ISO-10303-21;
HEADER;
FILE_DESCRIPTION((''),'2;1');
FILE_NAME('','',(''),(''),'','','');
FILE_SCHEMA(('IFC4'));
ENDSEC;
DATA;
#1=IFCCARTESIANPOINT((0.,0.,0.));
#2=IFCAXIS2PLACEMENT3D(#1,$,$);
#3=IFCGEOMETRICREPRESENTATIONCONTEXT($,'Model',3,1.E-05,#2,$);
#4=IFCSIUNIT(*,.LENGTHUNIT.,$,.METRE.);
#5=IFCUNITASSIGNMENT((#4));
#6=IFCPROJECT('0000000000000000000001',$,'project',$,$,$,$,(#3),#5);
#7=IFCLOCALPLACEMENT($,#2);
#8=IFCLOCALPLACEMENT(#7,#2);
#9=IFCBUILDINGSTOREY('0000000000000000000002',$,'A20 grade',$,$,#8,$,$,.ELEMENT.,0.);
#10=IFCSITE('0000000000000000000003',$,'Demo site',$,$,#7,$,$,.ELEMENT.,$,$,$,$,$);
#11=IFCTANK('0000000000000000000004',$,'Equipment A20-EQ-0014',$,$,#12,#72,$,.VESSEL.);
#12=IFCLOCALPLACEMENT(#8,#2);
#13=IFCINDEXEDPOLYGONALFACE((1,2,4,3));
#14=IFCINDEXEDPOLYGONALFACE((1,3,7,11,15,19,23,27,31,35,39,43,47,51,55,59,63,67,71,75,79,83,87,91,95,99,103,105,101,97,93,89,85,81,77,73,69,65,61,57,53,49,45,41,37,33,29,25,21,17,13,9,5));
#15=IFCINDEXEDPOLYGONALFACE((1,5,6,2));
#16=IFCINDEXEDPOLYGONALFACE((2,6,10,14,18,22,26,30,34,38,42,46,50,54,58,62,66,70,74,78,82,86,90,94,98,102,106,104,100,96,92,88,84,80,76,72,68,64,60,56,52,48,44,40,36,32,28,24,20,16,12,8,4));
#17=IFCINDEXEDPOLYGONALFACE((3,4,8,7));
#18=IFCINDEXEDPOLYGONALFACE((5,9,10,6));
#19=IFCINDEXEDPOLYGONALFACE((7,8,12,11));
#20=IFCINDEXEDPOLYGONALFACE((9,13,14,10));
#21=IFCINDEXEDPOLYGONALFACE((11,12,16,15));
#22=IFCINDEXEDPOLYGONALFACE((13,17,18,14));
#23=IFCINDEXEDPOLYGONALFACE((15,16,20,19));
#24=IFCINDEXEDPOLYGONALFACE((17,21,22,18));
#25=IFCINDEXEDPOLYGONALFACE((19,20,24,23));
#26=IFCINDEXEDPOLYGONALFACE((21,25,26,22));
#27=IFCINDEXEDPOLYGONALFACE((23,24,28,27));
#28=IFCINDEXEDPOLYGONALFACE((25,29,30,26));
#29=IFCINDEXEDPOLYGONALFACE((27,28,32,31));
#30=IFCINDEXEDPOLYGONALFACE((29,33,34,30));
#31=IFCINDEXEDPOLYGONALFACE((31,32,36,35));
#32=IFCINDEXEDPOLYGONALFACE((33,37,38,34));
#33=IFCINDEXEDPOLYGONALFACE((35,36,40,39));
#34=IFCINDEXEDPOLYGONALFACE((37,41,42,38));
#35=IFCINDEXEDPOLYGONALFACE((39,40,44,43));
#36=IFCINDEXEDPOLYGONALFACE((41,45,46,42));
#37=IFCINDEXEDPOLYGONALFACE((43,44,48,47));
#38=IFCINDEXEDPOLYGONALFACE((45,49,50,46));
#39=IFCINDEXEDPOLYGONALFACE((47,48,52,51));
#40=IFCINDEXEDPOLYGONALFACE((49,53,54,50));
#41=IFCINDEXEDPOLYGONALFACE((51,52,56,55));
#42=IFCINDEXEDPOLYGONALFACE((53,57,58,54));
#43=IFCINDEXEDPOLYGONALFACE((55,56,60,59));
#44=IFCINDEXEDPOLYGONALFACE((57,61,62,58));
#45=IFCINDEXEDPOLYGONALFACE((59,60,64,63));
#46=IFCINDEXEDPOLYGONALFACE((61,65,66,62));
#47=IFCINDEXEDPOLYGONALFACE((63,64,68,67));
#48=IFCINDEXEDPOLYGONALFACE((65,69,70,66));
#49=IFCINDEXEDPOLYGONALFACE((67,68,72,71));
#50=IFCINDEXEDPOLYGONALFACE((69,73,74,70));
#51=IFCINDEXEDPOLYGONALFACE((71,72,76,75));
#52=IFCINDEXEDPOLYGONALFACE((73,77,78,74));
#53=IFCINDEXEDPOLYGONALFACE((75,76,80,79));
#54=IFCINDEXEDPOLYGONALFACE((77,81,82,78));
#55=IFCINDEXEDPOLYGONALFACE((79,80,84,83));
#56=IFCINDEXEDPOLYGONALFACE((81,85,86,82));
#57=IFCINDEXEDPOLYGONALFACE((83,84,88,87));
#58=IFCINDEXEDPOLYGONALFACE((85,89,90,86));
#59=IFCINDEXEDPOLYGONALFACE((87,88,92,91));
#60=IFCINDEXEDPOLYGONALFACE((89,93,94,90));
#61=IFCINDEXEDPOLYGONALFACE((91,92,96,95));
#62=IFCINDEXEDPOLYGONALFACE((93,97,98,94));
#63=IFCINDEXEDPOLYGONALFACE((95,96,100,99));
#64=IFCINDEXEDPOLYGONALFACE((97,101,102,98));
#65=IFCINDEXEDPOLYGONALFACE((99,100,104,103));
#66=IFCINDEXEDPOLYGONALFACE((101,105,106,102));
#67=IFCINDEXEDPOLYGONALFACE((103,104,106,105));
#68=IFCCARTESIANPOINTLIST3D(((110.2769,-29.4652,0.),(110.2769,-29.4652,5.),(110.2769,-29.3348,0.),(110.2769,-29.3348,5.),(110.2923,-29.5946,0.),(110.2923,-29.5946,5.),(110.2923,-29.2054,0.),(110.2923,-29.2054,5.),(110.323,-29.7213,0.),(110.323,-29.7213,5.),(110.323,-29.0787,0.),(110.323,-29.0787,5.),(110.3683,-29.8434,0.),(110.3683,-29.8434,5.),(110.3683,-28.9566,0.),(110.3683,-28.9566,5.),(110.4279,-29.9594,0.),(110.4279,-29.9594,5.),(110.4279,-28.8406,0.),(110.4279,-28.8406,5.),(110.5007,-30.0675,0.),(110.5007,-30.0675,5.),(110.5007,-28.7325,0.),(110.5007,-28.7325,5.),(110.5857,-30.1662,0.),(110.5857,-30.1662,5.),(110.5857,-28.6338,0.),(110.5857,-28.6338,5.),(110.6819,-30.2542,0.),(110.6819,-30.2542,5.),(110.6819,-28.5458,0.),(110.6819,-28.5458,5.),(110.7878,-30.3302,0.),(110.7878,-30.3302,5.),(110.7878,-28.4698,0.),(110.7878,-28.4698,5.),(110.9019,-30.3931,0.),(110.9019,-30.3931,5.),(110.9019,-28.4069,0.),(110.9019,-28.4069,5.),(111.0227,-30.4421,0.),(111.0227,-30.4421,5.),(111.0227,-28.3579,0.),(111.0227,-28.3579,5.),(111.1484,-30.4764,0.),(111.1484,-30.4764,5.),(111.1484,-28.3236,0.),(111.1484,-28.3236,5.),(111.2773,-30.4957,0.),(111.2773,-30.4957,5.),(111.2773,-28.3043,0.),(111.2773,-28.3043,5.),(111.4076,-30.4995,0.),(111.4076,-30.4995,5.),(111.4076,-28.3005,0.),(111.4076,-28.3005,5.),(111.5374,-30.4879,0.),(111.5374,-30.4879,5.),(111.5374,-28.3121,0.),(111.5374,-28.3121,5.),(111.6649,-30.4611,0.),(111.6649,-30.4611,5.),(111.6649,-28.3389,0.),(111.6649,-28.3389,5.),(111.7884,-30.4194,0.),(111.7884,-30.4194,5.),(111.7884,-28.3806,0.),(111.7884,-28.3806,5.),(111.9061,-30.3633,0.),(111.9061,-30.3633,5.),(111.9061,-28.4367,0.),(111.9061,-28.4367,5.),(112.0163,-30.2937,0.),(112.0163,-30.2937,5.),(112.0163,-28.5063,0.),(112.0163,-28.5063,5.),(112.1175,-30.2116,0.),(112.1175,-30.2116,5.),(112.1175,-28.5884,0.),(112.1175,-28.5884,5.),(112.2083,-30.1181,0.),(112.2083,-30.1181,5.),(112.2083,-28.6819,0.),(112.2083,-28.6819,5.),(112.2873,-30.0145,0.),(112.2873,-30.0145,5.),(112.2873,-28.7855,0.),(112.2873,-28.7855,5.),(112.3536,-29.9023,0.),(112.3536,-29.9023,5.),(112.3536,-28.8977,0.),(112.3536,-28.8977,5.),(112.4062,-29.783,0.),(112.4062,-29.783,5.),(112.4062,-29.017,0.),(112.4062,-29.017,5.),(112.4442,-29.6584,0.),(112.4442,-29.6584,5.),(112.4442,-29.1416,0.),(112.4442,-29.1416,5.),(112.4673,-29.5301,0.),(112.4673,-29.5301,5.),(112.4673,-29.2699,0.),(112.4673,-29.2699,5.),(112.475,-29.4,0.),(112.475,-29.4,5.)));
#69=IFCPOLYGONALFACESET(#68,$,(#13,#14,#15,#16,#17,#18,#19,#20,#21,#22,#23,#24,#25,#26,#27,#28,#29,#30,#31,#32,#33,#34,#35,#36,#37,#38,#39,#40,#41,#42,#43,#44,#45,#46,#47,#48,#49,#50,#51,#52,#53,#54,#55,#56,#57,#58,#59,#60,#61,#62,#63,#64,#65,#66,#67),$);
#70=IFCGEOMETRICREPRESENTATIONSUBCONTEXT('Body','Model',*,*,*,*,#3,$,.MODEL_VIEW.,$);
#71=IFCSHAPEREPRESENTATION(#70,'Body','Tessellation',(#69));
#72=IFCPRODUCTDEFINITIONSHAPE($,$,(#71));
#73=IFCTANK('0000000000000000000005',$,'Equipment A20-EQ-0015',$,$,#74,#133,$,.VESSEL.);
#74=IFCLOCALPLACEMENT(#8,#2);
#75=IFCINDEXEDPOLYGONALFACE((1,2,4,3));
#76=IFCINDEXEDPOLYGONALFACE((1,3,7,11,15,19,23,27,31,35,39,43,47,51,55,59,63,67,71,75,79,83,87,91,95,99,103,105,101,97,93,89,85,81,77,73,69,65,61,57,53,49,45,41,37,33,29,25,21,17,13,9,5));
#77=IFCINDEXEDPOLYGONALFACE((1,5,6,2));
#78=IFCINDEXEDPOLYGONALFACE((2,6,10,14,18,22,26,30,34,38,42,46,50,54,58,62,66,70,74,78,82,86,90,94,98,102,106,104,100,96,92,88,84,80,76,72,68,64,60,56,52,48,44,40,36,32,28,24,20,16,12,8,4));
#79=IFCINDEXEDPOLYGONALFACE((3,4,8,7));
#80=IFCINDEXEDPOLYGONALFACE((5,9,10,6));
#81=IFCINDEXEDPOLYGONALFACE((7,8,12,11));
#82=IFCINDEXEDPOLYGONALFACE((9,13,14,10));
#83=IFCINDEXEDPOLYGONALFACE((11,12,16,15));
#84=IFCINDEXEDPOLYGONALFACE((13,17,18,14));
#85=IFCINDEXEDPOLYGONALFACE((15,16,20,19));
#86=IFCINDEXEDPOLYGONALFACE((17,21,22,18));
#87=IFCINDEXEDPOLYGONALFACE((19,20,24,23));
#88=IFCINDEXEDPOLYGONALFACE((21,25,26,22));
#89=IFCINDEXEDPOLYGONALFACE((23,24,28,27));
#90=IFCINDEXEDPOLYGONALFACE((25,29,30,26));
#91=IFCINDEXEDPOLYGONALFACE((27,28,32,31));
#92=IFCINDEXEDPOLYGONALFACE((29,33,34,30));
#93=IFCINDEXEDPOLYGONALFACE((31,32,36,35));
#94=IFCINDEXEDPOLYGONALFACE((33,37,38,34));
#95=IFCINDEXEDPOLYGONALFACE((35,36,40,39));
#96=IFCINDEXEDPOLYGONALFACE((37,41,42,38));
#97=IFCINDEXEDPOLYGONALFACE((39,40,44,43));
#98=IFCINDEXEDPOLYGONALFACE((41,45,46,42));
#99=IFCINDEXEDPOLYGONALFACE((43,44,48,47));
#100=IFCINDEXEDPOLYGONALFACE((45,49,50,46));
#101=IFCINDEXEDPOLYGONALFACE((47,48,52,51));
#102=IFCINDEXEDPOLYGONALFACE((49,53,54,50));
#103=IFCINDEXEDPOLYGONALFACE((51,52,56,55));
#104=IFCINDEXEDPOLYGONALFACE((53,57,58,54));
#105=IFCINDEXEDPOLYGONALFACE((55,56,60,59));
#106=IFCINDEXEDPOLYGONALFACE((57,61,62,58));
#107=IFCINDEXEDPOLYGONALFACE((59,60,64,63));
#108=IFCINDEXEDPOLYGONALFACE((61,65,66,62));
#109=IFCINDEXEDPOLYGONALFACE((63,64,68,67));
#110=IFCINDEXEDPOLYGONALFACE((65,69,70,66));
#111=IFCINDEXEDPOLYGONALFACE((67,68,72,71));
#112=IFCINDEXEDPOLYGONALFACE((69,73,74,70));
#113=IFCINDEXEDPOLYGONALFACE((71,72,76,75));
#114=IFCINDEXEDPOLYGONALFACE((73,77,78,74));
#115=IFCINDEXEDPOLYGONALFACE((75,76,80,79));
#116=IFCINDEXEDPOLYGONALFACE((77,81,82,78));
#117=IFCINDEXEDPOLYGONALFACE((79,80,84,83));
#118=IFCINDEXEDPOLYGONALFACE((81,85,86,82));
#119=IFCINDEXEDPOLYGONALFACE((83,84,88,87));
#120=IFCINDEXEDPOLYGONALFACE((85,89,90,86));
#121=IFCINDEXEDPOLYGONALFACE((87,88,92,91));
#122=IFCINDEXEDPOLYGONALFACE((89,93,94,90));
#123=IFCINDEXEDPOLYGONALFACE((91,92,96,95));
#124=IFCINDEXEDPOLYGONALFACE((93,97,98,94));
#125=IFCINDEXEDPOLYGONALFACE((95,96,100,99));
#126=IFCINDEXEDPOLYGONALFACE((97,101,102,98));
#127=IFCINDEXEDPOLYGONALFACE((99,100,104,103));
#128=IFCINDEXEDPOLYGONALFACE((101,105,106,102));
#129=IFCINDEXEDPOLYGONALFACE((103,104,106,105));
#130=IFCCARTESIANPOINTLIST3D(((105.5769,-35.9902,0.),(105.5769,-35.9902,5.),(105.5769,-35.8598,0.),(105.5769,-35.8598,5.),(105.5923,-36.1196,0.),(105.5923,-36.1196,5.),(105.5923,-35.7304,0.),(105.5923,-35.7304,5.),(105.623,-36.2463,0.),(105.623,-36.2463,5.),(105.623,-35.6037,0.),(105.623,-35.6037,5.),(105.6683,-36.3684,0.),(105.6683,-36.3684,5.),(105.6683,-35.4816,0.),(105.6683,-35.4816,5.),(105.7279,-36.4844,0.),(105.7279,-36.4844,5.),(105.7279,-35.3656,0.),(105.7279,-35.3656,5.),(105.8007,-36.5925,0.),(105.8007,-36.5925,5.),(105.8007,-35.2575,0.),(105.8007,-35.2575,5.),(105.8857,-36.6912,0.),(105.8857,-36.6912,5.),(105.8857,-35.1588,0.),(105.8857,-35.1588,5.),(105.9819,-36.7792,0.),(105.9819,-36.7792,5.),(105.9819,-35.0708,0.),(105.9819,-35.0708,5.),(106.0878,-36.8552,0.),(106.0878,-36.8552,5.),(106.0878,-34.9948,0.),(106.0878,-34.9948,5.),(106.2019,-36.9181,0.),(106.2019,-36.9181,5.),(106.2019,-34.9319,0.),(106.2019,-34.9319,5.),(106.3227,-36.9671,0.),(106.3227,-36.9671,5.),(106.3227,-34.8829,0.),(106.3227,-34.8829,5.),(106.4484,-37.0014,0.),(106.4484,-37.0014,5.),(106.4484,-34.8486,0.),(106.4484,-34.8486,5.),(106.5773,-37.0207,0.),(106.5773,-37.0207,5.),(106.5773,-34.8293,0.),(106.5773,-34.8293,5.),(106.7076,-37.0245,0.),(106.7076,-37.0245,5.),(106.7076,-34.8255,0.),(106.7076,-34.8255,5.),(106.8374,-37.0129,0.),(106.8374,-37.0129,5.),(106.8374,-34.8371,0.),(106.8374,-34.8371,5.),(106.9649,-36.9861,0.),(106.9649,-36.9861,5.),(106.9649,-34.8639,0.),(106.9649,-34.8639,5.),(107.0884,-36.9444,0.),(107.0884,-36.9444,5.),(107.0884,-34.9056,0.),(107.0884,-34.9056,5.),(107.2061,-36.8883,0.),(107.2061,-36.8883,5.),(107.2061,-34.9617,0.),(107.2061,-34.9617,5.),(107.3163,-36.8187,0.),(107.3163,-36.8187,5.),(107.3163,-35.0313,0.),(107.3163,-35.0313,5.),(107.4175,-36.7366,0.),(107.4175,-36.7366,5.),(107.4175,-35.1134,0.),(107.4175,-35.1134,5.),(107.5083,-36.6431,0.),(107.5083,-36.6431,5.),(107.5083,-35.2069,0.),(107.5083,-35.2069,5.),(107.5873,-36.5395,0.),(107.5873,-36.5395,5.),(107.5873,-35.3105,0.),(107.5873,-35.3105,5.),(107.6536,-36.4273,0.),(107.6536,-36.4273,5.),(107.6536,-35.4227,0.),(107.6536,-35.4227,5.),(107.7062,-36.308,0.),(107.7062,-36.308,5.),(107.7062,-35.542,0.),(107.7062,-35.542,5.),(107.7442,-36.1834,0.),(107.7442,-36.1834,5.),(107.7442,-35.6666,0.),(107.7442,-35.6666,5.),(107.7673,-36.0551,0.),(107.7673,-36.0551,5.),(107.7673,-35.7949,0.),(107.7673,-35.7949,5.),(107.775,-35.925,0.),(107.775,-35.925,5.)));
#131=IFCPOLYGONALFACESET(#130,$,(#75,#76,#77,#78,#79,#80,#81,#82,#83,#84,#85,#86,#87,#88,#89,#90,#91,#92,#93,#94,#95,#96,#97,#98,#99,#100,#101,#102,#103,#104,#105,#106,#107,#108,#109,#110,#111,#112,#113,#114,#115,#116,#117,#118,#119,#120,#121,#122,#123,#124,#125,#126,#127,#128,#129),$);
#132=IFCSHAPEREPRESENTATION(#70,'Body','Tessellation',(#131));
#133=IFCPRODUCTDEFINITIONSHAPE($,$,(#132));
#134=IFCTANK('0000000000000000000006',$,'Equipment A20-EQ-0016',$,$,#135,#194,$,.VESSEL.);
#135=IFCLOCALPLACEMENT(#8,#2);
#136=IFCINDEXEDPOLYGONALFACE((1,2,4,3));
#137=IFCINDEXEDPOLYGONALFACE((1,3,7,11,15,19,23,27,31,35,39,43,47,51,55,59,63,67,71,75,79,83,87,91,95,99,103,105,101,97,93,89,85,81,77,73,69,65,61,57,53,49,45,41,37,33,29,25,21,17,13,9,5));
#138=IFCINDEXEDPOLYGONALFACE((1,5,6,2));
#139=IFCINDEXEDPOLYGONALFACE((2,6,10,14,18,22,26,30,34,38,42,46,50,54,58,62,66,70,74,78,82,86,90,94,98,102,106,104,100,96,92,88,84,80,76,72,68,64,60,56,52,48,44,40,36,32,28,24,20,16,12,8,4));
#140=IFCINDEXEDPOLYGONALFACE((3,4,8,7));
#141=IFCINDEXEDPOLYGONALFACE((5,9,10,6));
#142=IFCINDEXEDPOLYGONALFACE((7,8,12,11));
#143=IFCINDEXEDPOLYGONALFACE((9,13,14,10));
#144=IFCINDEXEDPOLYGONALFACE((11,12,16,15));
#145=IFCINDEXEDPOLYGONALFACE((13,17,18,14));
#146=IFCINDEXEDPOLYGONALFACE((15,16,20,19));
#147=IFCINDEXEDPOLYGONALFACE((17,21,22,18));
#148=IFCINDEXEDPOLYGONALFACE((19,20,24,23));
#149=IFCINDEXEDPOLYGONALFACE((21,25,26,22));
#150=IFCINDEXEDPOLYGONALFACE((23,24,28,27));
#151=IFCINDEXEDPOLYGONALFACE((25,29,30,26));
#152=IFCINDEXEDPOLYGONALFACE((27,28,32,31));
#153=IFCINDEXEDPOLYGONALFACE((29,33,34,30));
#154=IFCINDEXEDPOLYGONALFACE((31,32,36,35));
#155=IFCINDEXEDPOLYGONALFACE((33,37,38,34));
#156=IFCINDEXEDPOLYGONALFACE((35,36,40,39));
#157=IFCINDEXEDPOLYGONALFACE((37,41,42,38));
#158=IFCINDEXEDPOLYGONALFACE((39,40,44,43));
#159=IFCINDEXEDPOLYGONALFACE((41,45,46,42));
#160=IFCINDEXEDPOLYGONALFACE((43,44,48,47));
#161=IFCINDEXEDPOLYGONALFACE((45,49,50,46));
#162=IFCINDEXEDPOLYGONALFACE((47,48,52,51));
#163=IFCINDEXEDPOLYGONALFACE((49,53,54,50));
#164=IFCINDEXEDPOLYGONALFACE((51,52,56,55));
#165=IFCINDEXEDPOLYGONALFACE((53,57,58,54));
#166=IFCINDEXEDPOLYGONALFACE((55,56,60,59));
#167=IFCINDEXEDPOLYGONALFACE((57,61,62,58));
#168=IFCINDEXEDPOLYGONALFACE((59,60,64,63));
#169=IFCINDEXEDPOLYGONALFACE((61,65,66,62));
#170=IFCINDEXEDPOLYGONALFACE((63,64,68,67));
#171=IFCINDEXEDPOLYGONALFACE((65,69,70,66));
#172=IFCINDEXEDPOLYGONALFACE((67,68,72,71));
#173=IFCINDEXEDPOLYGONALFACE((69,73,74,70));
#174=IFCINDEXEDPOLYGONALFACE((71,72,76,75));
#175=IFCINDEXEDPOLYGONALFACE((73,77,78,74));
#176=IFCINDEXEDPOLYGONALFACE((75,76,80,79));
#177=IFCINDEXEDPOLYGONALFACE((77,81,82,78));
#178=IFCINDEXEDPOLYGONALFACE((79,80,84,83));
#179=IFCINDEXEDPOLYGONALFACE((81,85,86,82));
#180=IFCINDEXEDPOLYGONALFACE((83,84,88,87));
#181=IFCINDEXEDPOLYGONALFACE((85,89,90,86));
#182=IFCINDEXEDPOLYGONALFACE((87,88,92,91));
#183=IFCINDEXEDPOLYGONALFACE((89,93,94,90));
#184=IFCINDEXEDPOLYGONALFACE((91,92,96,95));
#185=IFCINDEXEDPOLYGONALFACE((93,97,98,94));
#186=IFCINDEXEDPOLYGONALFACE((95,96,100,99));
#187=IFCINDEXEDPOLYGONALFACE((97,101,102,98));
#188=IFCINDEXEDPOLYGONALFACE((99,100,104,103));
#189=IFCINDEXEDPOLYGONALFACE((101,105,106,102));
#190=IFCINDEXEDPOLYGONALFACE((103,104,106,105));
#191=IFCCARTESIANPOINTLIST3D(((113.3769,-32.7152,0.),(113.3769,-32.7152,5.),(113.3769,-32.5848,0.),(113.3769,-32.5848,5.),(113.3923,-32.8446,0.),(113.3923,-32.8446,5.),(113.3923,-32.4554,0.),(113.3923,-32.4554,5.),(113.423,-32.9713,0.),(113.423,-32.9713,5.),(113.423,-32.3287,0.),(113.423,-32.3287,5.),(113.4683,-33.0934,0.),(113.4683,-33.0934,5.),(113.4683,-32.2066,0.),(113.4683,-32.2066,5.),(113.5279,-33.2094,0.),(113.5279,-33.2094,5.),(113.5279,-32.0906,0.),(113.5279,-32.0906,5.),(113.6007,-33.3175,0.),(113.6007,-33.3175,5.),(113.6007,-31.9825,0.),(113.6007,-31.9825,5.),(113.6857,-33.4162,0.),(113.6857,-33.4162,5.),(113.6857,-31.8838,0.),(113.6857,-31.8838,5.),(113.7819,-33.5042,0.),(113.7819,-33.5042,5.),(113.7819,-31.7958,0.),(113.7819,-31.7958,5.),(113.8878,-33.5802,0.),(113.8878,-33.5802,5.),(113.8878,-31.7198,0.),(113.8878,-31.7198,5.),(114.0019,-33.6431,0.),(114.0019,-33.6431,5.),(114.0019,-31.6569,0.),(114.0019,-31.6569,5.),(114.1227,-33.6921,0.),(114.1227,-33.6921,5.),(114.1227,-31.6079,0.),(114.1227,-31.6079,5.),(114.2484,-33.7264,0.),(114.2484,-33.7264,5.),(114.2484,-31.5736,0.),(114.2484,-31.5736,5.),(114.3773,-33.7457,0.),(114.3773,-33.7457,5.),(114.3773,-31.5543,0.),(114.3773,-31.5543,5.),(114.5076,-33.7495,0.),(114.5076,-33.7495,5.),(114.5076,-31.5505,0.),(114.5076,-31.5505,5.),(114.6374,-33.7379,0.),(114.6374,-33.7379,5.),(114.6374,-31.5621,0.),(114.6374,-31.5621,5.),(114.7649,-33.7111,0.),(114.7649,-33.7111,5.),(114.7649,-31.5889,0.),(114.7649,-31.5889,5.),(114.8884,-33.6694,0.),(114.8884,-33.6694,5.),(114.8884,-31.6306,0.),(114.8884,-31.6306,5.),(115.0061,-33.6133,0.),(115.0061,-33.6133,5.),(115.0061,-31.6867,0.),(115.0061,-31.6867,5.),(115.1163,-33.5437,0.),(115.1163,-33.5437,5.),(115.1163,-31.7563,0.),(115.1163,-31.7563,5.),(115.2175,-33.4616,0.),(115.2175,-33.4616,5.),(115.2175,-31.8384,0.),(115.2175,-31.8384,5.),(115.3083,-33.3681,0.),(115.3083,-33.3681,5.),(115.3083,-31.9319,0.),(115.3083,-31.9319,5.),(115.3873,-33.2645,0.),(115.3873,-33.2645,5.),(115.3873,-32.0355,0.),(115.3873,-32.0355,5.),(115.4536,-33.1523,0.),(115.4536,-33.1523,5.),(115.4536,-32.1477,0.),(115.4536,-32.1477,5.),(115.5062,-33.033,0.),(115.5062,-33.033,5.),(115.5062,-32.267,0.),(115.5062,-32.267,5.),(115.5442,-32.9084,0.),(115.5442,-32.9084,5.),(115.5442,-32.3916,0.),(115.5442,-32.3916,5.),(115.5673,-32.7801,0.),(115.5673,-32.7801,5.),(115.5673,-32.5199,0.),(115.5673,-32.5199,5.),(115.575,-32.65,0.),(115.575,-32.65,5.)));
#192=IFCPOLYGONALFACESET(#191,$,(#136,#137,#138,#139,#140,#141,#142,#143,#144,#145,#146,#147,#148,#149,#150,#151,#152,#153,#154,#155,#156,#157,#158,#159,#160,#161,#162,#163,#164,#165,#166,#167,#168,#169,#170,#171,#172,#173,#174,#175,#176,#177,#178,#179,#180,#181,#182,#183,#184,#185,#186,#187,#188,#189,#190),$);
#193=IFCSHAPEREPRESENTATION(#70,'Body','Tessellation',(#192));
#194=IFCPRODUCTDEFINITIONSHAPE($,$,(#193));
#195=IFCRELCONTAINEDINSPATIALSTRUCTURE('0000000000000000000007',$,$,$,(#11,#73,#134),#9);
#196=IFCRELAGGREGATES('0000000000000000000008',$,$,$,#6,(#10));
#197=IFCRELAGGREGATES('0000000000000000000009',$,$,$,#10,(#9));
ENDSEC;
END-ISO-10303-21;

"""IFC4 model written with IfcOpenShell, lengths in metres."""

from ifc_helpers import new_model, si_unit, frame, origin, place, context, subcontext, project, spatial, circle, extrude, element, save


model = new_model("IFC4")

# Units and contexts
model_context = context("Model", 3, precision=1e-05, world=origin())
body_context = subcontext(model_context, "Body", "Model", "MODEL_VIEW")
ifc_project = project(units=[si_unit("LENGTHUNIT", "METRE")], contexts=[model_context])

# Site, storey
site_placement = place(None, origin())
site = spatial("IfcSite", under=ifc_project, at=site_placement, Name="Demo site", CompositionType="ELEMENT")
storey_placement = place(site_placement, origin())
storey = spatial("IfcBuildingStorey", under=site, at=storey_placement, Name="A20 grade", CompositionType="ELEMENT", Elevation=0.0)

# Tanks
for number, where, name in (
    (1, (111.375, -29.4, 0.0), "Equipment A20-EQ-0014"),
    (2, (106.675, -35.925, 0.0), "Equipment A20-EQ-0015"),
    (3, (114.475, -32.65, 0.0), "Equipment A20-EQ-0016"),
):
    element("IfcTank", number, at=place(storey_placement, frame(where)), inside=storey, Name=name, PredefinedType="VESSEL", context=body_context, shape_type="SweptSolid", body=[
        extrude(circle(Radius=1.1), origin(), (0.0, 0.0, 1.0), 5.0),
    ])

save(model, "model.ifc")
